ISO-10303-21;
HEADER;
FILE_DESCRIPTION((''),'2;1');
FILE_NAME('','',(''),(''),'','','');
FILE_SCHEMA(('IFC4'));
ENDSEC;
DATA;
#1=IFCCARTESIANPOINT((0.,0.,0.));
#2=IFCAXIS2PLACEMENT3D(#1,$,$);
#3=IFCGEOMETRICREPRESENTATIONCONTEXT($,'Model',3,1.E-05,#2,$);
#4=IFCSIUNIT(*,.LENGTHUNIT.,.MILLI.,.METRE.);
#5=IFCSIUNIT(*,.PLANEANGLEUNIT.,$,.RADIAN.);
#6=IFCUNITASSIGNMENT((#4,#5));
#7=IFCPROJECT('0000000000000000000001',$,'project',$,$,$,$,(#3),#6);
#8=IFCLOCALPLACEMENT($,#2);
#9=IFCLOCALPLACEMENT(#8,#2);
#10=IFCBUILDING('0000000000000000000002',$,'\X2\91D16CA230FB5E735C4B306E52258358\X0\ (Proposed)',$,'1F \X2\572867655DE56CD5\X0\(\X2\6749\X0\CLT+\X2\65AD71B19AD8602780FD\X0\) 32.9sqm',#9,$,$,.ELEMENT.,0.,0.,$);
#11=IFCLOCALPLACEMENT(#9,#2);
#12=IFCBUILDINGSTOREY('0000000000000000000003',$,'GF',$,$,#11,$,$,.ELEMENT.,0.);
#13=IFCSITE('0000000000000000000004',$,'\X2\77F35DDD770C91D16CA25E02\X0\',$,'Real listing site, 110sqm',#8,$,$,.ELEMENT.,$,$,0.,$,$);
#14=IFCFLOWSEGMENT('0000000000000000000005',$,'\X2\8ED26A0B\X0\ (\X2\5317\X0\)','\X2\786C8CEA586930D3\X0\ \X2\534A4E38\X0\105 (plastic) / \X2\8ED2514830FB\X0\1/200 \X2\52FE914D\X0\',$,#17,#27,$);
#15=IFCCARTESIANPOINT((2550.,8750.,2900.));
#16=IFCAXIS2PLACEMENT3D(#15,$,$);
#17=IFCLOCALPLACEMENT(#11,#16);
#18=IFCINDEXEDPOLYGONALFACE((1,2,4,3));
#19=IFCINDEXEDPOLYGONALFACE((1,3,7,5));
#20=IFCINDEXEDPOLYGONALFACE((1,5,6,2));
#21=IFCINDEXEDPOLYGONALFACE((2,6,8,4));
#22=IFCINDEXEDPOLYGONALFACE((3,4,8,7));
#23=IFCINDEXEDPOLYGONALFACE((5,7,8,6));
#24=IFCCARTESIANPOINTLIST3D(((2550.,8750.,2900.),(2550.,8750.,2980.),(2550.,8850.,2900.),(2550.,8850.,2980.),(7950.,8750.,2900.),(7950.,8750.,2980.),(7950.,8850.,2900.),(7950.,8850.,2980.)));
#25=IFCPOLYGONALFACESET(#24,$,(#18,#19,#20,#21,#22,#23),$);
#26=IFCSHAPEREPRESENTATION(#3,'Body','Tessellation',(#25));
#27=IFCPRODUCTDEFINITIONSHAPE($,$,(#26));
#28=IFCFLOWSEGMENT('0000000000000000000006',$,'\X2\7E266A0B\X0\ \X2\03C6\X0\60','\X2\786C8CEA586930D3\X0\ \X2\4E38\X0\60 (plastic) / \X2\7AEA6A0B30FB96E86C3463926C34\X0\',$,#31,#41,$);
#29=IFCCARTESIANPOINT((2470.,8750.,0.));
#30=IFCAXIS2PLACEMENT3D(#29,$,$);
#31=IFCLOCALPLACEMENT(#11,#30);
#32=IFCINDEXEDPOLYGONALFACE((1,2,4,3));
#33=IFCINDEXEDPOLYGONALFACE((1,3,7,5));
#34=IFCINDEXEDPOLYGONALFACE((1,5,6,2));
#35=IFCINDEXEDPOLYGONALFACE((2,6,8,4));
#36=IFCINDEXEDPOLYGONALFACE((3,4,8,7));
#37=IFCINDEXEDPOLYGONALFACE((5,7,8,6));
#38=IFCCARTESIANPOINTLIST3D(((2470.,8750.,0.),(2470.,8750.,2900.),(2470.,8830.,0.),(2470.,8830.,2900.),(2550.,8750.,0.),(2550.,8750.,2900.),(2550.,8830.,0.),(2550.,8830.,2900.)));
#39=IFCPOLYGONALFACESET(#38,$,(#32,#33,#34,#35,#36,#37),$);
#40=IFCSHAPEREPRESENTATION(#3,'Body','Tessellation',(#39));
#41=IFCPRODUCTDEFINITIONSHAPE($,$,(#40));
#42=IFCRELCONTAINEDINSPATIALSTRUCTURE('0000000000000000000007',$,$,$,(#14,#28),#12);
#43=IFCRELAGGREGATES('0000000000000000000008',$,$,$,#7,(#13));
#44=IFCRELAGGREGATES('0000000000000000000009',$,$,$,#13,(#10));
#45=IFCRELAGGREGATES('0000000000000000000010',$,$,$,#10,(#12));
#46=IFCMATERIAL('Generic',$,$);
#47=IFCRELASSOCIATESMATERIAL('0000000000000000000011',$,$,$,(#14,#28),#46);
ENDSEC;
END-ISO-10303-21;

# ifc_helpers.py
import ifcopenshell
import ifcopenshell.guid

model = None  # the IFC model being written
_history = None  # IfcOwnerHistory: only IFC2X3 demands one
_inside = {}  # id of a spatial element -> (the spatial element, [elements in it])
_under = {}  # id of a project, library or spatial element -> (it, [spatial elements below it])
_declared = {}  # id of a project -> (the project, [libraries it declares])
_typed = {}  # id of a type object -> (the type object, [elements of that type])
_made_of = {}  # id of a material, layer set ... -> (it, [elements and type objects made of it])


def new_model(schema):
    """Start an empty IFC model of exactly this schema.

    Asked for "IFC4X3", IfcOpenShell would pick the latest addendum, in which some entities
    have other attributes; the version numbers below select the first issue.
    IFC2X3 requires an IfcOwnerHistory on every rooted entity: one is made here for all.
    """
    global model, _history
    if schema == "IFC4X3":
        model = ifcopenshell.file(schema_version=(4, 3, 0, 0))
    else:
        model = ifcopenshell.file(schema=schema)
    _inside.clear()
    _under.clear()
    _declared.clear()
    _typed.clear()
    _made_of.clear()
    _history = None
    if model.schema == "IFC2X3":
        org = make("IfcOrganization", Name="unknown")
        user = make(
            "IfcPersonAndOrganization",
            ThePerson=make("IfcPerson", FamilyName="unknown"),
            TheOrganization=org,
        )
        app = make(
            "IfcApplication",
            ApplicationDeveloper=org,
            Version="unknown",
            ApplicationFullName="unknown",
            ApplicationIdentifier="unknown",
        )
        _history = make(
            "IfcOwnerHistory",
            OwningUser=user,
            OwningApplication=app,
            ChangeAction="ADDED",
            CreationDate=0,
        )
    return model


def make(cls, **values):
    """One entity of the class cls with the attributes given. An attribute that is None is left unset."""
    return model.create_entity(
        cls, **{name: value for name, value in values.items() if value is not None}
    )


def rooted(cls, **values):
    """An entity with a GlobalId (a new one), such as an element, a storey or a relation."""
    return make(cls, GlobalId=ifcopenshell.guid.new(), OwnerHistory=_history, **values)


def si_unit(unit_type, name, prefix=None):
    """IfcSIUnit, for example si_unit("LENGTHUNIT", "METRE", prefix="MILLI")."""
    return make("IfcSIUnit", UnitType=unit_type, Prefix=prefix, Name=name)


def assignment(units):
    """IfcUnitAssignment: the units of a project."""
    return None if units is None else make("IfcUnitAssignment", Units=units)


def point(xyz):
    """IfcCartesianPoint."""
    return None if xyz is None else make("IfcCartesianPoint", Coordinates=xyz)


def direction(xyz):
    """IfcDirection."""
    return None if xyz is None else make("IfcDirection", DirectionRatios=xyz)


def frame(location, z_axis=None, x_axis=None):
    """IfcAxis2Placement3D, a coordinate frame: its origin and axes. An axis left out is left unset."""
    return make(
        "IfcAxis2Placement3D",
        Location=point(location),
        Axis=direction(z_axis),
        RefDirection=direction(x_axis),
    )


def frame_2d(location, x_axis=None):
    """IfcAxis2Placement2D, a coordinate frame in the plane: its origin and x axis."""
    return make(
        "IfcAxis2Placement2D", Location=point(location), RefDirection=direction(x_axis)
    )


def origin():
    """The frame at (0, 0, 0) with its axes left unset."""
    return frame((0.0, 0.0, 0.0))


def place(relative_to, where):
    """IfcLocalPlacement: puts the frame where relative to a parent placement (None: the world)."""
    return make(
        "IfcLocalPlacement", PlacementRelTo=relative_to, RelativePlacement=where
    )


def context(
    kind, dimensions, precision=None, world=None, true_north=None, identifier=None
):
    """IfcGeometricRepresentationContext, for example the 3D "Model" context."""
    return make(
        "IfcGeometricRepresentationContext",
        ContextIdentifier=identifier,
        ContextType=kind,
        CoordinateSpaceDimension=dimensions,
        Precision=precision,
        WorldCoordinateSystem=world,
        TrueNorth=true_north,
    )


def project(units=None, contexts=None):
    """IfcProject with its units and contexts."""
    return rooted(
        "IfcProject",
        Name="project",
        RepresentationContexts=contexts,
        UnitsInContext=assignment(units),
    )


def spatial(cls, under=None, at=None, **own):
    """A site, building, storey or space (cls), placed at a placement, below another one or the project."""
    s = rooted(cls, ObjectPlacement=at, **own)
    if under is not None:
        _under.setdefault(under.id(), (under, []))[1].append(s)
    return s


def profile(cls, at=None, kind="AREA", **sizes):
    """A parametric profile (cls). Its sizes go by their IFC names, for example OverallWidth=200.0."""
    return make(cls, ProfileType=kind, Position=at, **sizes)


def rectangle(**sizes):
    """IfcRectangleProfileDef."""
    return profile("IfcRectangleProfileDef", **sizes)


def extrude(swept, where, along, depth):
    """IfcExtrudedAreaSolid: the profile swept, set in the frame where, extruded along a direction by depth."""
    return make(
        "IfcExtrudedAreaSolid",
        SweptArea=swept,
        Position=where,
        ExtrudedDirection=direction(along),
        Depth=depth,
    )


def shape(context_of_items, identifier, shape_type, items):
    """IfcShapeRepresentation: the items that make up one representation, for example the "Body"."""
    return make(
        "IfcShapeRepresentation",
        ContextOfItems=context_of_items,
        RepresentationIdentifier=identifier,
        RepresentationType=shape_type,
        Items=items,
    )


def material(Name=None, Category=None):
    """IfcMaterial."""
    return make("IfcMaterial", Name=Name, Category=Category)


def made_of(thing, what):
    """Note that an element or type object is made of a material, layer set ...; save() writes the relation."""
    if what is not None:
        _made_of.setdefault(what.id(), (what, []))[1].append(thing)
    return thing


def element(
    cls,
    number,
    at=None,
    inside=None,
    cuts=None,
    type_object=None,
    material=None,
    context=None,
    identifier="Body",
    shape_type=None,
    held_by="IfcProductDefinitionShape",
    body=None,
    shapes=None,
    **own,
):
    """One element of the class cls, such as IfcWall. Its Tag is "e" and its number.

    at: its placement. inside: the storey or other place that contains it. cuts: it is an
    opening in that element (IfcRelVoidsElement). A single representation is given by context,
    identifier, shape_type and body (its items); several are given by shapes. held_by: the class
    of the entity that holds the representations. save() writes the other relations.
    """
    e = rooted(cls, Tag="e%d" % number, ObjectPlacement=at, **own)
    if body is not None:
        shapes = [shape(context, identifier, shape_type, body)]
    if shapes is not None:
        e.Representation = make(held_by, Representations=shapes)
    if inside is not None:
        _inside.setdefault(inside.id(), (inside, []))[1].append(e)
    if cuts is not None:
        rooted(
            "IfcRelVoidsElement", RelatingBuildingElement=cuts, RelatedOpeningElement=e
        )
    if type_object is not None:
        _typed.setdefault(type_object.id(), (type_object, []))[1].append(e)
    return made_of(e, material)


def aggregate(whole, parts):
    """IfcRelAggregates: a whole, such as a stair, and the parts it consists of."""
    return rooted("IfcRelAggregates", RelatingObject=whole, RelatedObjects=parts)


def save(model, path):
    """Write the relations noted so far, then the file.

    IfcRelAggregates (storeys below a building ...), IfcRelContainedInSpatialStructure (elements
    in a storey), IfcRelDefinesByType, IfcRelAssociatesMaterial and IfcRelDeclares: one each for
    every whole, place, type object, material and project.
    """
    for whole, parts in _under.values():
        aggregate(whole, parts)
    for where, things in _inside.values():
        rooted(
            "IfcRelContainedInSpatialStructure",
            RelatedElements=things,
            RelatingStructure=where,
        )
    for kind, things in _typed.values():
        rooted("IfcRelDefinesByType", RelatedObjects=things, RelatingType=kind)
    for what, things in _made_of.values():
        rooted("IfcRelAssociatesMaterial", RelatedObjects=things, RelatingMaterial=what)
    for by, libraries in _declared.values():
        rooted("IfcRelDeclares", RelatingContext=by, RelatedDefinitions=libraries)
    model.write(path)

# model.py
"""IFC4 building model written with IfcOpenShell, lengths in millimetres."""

from ifc_helpers import new_model, si_unit, frame, frame_2d, origin, place, context, project, spatial, rectangle, extrude, material, element, save


model = new_model("IFC4")

# Units and contexts
model_context = context("Model", 3, precision=1e-05, world=origin())
ifc_project = project(units=[si_unit("LENGTHUNIT", "METRE", prefix="MILLI"), si_unit("PLANEANGLEUNIT", "RADIAN")], contexts=[model_context])

# Site, building, storey
site_placement = place(None, origin())
site = spatial("IfcSite", under=ifc_project, at=site_placement, Name="石川県金沢市", ObjectType="Real listing site, 110sqm", CompositionType="ELEMENT", RefElevation=0.0)
building_placement = place(site_placement, origin())
building = spatial("IfcBuilding", under=site, at=building_placement, Name="金沢・平屋の別荘 (Proposed)", ObjectType="1F 在来工法(杉CLT+断熱高性能) 32.9sqm", CompositionType="ELEMENT", ElevationOfRefHeight=0.0, ElevationOfTerrain=0.0)
storey_placement = place(building_placement, origin())
storey = spatial("IfcBuildingStorey", under=building, at=storey_placement, Name="GF", CompositionType="ELEMENT", Elevation=0.0)

# Shared definitions
ifc_material_1 = material(Name="Generic")

# Flow segments
flow_segment_1_placement = place(storey_placement, frame((2550.0, 8750.0, 2900.0)))
element("IfcFlowSegment", 1, at=flow_segment_1_placement, inside=storey, material=ifc_material_1, Name="軒樋 (北)", Description="硬質塩ビ 半丸105 (plastic) / 軒先・1/200 勾配", context=model_context, shape_type="SweptSolid", body=[
    extrude(rectangle(XDim=5400.0, YDim=100.0, at=frame_2d((2700.0, 50.0))), frame((2550.0, 8750.0, 2900.0)), (0.0, 0.0, 1.0), 80.0),
])
flow_segment_2_placement = place(storey_placement, frame((2470.0, 8750.0, 0.0)))
element("IfcFlowSegment", 2, at=flow_segment_2_placement, inside=storey, material=ifc_material_1, Name="縦樋 φ60", Description="硬質塩ビ 丸60 (plastic) / 竪樋・雨水排水", context=model_context, shape_type="SweptSolid", body=[
    extrude(rectangle(XDim=80.0, YDim=80.0, at=frame_2d((40.0, 40.0))), frame((2470.0, 8750.0, 0.0)), (0.0, 0.0, 1.0), 2900.0),
])

save(model, "model.ifc")
